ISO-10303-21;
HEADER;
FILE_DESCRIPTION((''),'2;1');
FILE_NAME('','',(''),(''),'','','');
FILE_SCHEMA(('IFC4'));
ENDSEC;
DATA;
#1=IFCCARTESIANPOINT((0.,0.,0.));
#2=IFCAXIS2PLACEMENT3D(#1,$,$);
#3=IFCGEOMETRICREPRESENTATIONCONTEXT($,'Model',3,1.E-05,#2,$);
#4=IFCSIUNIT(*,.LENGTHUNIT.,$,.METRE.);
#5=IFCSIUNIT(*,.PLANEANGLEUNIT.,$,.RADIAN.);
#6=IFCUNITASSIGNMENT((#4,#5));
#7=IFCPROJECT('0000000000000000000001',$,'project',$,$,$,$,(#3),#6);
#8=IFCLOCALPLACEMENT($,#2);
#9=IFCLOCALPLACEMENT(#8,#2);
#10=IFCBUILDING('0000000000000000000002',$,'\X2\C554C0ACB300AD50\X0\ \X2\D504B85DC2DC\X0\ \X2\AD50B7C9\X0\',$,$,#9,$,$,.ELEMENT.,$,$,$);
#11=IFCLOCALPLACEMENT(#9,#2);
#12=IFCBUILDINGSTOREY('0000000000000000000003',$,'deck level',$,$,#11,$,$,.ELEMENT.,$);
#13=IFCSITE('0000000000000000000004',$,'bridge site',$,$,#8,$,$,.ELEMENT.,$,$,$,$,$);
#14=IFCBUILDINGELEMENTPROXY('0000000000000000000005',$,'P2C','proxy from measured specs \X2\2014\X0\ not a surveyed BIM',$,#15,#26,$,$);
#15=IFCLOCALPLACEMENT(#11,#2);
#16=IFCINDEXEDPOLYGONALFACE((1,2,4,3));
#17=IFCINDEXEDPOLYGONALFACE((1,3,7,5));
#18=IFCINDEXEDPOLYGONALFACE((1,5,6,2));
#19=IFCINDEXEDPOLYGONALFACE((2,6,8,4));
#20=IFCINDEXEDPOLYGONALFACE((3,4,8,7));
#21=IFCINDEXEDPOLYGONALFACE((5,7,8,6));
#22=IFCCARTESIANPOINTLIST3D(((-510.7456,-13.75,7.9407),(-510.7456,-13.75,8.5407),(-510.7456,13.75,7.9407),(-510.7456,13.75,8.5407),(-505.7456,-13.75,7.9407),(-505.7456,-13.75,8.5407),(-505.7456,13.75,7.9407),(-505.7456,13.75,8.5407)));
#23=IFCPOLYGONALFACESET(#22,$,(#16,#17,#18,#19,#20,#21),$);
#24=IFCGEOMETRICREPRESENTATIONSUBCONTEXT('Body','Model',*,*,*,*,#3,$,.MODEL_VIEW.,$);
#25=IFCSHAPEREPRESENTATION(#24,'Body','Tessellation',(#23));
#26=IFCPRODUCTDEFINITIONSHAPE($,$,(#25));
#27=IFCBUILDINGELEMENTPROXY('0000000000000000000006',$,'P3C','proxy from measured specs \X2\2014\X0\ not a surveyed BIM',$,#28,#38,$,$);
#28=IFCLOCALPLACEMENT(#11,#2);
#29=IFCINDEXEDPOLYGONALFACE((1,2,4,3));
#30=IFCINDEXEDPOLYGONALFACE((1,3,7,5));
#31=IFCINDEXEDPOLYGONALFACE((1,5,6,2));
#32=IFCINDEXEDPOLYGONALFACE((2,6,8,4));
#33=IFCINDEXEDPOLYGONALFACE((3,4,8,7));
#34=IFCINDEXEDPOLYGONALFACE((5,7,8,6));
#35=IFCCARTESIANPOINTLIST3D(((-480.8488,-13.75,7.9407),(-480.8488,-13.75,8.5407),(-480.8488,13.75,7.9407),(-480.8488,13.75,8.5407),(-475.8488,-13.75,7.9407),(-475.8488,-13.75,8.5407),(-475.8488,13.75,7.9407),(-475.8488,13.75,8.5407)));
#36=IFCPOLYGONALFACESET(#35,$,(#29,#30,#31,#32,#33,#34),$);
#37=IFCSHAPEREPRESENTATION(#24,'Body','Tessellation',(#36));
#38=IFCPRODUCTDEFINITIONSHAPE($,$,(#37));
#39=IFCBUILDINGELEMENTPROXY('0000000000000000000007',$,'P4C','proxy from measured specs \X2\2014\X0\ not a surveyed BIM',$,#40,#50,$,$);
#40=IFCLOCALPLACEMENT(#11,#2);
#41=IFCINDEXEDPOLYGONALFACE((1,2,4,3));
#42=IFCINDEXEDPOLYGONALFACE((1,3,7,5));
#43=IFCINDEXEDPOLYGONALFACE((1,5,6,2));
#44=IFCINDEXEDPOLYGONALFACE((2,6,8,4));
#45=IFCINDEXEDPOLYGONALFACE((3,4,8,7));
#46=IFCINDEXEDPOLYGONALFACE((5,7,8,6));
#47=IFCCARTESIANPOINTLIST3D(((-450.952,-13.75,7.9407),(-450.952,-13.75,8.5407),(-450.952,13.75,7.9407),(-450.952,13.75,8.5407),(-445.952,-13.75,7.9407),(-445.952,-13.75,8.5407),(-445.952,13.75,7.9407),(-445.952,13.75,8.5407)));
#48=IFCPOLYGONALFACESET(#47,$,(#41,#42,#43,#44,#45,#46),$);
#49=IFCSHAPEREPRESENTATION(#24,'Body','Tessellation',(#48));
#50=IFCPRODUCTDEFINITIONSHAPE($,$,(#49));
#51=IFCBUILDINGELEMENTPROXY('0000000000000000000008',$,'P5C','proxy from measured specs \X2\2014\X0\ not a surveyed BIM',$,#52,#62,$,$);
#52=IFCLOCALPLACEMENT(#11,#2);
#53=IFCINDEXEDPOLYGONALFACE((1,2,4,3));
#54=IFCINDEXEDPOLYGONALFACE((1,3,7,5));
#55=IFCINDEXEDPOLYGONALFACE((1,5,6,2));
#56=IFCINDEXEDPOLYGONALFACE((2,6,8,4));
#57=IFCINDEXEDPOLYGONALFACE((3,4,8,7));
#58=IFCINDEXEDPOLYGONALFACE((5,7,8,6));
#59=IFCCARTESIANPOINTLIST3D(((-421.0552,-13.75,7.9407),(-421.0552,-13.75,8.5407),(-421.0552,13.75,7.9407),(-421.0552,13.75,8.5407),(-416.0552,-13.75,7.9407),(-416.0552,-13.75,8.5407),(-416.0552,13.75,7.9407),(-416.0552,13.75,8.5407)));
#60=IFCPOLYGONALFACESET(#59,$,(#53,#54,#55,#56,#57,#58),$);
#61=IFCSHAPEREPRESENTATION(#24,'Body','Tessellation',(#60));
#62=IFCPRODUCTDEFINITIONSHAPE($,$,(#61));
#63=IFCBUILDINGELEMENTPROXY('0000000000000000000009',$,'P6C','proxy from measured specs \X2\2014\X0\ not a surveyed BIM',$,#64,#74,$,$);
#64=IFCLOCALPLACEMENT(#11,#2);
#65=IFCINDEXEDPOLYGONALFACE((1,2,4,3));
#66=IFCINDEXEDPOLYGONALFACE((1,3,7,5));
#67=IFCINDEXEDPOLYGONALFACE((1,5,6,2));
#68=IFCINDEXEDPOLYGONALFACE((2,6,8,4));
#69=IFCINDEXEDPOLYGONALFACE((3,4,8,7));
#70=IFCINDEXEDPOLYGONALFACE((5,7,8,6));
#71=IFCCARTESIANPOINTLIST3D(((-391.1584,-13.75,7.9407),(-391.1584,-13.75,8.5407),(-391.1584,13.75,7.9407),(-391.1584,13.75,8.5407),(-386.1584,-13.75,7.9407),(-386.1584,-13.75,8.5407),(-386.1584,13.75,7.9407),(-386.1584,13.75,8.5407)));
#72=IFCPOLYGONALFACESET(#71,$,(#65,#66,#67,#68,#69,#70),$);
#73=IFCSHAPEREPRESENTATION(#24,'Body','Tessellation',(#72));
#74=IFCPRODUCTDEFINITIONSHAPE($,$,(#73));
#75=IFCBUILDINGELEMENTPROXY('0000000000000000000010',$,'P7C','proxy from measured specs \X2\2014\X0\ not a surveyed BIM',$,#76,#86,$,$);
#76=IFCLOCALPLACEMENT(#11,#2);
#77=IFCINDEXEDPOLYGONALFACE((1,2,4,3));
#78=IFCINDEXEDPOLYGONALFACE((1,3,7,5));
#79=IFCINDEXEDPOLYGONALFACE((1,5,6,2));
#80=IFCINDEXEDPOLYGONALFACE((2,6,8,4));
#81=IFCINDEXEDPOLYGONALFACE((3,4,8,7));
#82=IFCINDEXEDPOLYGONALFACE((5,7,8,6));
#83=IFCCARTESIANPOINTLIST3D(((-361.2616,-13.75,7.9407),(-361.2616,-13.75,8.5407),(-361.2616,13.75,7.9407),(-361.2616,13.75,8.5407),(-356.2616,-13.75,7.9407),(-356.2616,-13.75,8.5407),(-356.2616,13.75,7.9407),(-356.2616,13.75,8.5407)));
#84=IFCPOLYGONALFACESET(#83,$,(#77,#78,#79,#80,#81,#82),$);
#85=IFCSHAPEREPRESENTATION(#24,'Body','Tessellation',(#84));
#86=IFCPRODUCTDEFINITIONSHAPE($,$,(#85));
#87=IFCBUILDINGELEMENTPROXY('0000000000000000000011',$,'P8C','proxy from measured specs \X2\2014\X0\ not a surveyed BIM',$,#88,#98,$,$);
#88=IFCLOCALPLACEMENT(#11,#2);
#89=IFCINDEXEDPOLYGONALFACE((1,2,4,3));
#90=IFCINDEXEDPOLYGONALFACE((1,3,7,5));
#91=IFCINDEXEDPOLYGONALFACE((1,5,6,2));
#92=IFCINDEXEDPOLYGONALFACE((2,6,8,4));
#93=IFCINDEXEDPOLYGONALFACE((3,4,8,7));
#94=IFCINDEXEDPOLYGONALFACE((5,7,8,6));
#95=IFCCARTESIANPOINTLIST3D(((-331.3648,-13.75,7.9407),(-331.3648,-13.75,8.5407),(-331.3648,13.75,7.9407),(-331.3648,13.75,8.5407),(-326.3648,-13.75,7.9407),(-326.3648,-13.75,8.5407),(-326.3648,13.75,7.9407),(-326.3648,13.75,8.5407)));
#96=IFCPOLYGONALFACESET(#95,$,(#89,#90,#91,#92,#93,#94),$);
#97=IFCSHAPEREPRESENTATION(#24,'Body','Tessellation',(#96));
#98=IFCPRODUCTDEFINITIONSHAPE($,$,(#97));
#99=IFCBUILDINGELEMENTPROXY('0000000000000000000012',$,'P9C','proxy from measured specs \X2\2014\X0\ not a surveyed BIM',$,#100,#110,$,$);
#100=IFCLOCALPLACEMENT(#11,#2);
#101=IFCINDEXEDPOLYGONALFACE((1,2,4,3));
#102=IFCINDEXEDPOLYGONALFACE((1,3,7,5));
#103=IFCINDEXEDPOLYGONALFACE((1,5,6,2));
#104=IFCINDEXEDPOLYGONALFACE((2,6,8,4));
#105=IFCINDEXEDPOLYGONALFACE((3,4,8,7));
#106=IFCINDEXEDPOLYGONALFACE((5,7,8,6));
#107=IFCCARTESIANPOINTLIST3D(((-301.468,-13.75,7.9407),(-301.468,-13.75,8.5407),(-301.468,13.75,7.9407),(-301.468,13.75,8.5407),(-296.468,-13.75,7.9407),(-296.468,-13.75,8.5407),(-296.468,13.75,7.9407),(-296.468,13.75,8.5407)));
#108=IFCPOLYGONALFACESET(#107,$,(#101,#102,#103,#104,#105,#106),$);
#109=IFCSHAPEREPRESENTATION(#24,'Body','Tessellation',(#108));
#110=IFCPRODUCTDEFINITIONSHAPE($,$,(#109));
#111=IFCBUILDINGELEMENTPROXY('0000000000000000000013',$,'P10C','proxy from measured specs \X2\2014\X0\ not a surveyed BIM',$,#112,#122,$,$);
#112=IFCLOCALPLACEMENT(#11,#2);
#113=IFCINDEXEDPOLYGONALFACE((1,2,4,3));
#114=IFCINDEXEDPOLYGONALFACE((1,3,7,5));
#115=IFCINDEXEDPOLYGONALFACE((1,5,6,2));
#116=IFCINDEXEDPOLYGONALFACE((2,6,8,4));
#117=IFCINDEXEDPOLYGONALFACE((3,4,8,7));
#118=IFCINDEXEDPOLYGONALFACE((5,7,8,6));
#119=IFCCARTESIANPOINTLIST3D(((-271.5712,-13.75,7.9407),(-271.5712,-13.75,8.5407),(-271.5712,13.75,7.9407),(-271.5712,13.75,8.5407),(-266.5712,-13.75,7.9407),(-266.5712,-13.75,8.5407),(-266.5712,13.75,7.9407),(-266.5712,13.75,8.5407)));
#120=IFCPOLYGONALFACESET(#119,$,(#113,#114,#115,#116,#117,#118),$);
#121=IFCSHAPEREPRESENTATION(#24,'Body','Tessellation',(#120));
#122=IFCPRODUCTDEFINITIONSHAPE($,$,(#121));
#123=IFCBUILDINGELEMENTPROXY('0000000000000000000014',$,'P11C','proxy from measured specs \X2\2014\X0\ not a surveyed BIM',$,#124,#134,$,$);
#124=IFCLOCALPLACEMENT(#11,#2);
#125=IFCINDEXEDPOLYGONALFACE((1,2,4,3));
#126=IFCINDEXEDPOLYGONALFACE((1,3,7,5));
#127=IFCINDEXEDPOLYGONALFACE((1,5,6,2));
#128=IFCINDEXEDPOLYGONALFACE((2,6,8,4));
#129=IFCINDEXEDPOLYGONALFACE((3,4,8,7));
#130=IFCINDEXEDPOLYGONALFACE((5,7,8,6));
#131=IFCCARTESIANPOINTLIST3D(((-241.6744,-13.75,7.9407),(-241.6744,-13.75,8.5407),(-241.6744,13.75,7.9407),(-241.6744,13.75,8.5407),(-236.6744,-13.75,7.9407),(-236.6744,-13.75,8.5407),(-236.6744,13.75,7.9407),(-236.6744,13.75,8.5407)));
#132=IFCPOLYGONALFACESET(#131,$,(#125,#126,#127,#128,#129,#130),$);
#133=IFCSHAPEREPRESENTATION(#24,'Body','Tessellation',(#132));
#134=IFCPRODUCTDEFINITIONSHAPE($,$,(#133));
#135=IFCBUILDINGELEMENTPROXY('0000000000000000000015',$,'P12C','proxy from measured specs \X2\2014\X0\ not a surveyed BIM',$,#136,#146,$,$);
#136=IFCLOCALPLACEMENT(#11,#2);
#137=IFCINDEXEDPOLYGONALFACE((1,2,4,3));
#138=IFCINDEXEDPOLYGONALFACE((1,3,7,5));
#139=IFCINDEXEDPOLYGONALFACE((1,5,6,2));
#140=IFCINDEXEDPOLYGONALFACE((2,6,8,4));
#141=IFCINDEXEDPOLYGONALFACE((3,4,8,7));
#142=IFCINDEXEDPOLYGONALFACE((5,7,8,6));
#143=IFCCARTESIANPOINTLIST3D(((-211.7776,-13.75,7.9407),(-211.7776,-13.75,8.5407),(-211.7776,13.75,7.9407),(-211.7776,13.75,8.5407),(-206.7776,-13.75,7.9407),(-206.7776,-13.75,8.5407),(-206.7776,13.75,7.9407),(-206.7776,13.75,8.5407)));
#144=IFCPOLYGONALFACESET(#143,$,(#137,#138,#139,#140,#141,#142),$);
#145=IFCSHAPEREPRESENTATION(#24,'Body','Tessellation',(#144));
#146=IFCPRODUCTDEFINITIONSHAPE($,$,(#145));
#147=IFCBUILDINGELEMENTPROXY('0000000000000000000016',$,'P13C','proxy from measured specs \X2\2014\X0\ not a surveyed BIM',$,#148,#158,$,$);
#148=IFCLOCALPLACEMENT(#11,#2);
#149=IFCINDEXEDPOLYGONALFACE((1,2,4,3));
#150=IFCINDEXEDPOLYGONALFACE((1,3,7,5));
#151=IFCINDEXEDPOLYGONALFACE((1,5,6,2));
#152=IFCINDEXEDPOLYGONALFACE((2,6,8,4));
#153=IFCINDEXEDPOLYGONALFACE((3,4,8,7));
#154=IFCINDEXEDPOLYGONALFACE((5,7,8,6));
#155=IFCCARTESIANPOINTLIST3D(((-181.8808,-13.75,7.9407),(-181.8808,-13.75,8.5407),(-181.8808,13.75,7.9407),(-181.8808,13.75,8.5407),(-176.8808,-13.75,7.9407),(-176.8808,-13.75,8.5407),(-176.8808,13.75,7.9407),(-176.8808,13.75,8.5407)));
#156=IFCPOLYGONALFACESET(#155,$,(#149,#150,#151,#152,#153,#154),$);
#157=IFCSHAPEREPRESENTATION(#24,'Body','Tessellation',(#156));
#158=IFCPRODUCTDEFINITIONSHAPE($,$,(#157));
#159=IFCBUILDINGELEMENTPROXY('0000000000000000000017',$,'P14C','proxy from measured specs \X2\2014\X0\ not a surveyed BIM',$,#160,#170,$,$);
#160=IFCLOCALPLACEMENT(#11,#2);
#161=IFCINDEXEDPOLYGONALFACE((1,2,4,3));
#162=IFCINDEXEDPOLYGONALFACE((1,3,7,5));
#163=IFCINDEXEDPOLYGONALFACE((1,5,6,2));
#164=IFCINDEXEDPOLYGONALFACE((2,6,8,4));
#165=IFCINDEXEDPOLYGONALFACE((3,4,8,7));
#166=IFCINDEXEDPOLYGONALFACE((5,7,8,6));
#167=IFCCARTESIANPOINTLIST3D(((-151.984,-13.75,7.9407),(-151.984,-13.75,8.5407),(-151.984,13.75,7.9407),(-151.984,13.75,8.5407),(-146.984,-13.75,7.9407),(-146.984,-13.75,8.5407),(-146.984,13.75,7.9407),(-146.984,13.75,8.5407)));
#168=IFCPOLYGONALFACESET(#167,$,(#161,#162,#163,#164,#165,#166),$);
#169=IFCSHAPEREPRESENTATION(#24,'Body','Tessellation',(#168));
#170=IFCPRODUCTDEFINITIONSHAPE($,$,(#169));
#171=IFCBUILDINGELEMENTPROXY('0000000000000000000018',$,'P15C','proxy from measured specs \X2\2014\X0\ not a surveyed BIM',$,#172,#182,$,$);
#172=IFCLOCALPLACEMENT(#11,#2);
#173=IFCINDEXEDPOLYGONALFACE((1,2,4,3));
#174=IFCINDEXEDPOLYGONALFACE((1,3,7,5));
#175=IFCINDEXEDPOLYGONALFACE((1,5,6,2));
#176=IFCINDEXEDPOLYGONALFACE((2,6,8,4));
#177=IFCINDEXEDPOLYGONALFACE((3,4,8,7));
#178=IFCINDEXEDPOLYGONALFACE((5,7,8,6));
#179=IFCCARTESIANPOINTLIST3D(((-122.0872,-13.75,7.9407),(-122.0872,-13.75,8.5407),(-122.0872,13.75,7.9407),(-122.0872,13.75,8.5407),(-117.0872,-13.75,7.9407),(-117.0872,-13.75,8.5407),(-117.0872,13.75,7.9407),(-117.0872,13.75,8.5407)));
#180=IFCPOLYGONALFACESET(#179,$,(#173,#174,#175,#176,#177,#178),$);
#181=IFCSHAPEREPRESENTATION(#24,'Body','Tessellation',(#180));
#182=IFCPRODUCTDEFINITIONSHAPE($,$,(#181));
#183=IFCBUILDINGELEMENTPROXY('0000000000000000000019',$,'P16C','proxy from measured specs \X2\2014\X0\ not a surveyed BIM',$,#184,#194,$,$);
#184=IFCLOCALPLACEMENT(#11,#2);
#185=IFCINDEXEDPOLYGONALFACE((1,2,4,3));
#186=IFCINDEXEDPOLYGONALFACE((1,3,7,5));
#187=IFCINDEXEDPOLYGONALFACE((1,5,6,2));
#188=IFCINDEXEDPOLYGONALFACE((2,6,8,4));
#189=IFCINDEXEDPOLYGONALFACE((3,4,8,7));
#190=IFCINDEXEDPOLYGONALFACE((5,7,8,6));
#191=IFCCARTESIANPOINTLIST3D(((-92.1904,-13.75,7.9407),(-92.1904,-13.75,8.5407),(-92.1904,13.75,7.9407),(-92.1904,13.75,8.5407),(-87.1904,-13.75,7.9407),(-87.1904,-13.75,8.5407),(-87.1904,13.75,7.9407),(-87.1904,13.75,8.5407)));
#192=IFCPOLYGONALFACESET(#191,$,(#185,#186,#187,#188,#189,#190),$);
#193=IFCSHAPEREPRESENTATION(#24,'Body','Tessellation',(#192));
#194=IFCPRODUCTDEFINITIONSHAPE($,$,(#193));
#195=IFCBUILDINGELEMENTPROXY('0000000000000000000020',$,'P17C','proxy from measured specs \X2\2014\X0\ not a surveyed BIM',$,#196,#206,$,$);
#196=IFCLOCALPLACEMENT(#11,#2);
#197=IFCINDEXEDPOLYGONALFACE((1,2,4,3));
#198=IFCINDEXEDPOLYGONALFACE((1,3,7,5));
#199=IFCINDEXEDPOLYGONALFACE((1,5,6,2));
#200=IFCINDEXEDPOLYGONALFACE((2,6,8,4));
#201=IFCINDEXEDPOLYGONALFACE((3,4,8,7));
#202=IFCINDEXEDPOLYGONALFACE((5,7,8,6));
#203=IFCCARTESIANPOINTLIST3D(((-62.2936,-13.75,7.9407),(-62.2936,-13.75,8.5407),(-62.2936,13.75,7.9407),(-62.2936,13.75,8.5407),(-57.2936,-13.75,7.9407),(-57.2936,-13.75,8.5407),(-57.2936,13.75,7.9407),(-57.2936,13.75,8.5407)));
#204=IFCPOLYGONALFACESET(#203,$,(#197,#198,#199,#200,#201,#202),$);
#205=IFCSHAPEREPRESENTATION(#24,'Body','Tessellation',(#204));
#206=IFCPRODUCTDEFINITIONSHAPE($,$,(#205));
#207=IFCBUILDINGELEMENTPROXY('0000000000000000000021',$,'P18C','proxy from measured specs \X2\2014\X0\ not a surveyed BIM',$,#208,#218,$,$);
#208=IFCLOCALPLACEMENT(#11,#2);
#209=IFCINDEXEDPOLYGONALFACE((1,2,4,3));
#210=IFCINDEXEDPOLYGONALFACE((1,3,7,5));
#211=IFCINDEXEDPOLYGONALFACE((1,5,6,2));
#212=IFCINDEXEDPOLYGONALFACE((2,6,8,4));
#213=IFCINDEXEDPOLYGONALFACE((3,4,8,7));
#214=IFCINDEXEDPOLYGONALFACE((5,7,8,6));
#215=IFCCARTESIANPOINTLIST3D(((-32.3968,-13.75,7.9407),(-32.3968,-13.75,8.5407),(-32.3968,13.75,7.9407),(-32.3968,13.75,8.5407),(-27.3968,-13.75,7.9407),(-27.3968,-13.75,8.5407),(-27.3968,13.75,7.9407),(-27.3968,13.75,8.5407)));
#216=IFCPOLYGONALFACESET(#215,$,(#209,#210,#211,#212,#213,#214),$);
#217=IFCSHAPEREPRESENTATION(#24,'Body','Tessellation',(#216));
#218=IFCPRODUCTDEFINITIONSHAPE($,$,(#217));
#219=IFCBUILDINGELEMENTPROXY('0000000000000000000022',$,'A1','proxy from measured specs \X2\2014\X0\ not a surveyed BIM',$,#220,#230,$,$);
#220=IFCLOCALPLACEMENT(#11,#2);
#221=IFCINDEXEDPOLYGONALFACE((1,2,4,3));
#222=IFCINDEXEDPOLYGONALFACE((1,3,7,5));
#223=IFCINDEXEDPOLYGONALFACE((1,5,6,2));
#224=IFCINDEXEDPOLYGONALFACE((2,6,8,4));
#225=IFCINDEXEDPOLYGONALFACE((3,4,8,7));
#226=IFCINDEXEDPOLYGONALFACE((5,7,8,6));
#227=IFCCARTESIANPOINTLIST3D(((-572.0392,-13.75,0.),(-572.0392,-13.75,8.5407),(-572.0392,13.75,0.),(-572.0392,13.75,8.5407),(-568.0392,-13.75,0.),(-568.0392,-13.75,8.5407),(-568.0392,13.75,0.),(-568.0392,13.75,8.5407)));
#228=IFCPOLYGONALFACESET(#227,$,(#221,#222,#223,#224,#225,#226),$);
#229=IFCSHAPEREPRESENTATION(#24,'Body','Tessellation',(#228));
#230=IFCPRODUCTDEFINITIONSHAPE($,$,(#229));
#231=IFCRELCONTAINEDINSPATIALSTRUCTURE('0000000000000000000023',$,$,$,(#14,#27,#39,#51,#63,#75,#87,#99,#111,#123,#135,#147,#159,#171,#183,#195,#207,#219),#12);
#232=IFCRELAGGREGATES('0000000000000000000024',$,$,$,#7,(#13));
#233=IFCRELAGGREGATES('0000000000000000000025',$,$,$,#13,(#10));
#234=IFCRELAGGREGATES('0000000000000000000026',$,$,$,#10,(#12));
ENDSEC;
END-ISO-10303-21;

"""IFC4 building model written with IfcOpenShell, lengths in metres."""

from ifc_helpers import new_model, si_unit, frame, origin, origin_2d, place, context, subcontext, project, spatial, rectangle, extrude, element, save


model = new_model("IFC4")

# Units and contexts
model_context = context("Model", 3, precision=1e-05, world=origin())
body_context = subcontext(model_context, "Body", "Model", "MODEL_VIEW")
ifc_project = project(units=[si_unit("LENGTHUNIT", "METRE"), si_unit("PLANEANGLEUNIT", "RADIAN")], contexts=[model_context])

# Site, building, storey
site_placement = place(None, origin())
site = spatial("IfcSite", under=ifc_project, at=site_placement, Name="bridge site", CompositionType="ELEMENT")
building_placement = place(site_placement, origin())
building = spatial("IfcBuilding", under=site, at=building_placement, Name="암사대교 프록시 교량", CompositionType="ELEMENT")
storey_placement = place(building_placement, origin())
storey = spatial("IfcBuildingStorey", under=building, at=storey_placement, Name="deck level", CompositionType="ELEMENT")

# Building element proxies
for number, where, name in (
    (1, (-508.2456, 0.0, 7.9407), "P2C"),
    (2, (-478.3488, 0.0, 7.9407), "P3C"),
    (3, (-448.452, 0.0, 7.9407), "P4C"),
    (4, (-418.5552, 0.0, 7.9407), "P5C"),
    (5, (-388.6584, 0.0, 7.9407), "P6C"),
    (6, (-358.7616, 0.0, 7.9407), "P7C"),
    (7, (-328.8648, 0.0, 7.9407), "P8C"),
    (8, (-298.968, 0.0, 7.9407), "P9C"),
    (9, (-269.0712, 0.0, 7.9407), "P10C"),
    (10, (-239.1744, 0.0, 7.9407), "P11C"),
    (11, (-209.2776, 0.0, 7.9407), "P12C"),
    (12, (-179.3808, 0.0, 7.9407), "P13C"),
    (13, (-149.484, 0.0, 7.9407), "P14C"),
    (14, (-119.5872, 0.0, 7.9407), "P15C"),
    (15, (-89.6904, 0.0, 7.9407), "P16C"),
    (16, (-59.7936, 0.0, 7.9407), "P17C"),
    (17, (-29.8968, 0.0, 7.9407), "P18C"),
):
    element("IfcBuildingElementProxy", number, at=place(storey_placement, frame(where)), inside=storey, Name=name, Description="proxy from measured specs — not a surveyed BIM", context=body_context, shape_type="SweptSolid", body=[
        extrude(rectangle(XDim=5.0, YDim=27.5, at=origin_2d()), origin(), (0.0, 0.0, 1.0), 0.6),
    ])
proxy_placement = place(storey_placement, frame((-570.0392, 0.0, 0.0)))
element("IfcBuildingElementProxy", 18, at=proxy_placement, inside=storey, Name="A1", Description="proxy from measured specs — not a surveyed BIM", context=body_context, shape_type="SweptSolid", body=[
    extrude(rectangle(XDim=4.0, YDim=27.5, at=origin_2d()), origin(), (0.0, 0.0, 1.0), 8.5407),
])

save(model, "model.ifc")
